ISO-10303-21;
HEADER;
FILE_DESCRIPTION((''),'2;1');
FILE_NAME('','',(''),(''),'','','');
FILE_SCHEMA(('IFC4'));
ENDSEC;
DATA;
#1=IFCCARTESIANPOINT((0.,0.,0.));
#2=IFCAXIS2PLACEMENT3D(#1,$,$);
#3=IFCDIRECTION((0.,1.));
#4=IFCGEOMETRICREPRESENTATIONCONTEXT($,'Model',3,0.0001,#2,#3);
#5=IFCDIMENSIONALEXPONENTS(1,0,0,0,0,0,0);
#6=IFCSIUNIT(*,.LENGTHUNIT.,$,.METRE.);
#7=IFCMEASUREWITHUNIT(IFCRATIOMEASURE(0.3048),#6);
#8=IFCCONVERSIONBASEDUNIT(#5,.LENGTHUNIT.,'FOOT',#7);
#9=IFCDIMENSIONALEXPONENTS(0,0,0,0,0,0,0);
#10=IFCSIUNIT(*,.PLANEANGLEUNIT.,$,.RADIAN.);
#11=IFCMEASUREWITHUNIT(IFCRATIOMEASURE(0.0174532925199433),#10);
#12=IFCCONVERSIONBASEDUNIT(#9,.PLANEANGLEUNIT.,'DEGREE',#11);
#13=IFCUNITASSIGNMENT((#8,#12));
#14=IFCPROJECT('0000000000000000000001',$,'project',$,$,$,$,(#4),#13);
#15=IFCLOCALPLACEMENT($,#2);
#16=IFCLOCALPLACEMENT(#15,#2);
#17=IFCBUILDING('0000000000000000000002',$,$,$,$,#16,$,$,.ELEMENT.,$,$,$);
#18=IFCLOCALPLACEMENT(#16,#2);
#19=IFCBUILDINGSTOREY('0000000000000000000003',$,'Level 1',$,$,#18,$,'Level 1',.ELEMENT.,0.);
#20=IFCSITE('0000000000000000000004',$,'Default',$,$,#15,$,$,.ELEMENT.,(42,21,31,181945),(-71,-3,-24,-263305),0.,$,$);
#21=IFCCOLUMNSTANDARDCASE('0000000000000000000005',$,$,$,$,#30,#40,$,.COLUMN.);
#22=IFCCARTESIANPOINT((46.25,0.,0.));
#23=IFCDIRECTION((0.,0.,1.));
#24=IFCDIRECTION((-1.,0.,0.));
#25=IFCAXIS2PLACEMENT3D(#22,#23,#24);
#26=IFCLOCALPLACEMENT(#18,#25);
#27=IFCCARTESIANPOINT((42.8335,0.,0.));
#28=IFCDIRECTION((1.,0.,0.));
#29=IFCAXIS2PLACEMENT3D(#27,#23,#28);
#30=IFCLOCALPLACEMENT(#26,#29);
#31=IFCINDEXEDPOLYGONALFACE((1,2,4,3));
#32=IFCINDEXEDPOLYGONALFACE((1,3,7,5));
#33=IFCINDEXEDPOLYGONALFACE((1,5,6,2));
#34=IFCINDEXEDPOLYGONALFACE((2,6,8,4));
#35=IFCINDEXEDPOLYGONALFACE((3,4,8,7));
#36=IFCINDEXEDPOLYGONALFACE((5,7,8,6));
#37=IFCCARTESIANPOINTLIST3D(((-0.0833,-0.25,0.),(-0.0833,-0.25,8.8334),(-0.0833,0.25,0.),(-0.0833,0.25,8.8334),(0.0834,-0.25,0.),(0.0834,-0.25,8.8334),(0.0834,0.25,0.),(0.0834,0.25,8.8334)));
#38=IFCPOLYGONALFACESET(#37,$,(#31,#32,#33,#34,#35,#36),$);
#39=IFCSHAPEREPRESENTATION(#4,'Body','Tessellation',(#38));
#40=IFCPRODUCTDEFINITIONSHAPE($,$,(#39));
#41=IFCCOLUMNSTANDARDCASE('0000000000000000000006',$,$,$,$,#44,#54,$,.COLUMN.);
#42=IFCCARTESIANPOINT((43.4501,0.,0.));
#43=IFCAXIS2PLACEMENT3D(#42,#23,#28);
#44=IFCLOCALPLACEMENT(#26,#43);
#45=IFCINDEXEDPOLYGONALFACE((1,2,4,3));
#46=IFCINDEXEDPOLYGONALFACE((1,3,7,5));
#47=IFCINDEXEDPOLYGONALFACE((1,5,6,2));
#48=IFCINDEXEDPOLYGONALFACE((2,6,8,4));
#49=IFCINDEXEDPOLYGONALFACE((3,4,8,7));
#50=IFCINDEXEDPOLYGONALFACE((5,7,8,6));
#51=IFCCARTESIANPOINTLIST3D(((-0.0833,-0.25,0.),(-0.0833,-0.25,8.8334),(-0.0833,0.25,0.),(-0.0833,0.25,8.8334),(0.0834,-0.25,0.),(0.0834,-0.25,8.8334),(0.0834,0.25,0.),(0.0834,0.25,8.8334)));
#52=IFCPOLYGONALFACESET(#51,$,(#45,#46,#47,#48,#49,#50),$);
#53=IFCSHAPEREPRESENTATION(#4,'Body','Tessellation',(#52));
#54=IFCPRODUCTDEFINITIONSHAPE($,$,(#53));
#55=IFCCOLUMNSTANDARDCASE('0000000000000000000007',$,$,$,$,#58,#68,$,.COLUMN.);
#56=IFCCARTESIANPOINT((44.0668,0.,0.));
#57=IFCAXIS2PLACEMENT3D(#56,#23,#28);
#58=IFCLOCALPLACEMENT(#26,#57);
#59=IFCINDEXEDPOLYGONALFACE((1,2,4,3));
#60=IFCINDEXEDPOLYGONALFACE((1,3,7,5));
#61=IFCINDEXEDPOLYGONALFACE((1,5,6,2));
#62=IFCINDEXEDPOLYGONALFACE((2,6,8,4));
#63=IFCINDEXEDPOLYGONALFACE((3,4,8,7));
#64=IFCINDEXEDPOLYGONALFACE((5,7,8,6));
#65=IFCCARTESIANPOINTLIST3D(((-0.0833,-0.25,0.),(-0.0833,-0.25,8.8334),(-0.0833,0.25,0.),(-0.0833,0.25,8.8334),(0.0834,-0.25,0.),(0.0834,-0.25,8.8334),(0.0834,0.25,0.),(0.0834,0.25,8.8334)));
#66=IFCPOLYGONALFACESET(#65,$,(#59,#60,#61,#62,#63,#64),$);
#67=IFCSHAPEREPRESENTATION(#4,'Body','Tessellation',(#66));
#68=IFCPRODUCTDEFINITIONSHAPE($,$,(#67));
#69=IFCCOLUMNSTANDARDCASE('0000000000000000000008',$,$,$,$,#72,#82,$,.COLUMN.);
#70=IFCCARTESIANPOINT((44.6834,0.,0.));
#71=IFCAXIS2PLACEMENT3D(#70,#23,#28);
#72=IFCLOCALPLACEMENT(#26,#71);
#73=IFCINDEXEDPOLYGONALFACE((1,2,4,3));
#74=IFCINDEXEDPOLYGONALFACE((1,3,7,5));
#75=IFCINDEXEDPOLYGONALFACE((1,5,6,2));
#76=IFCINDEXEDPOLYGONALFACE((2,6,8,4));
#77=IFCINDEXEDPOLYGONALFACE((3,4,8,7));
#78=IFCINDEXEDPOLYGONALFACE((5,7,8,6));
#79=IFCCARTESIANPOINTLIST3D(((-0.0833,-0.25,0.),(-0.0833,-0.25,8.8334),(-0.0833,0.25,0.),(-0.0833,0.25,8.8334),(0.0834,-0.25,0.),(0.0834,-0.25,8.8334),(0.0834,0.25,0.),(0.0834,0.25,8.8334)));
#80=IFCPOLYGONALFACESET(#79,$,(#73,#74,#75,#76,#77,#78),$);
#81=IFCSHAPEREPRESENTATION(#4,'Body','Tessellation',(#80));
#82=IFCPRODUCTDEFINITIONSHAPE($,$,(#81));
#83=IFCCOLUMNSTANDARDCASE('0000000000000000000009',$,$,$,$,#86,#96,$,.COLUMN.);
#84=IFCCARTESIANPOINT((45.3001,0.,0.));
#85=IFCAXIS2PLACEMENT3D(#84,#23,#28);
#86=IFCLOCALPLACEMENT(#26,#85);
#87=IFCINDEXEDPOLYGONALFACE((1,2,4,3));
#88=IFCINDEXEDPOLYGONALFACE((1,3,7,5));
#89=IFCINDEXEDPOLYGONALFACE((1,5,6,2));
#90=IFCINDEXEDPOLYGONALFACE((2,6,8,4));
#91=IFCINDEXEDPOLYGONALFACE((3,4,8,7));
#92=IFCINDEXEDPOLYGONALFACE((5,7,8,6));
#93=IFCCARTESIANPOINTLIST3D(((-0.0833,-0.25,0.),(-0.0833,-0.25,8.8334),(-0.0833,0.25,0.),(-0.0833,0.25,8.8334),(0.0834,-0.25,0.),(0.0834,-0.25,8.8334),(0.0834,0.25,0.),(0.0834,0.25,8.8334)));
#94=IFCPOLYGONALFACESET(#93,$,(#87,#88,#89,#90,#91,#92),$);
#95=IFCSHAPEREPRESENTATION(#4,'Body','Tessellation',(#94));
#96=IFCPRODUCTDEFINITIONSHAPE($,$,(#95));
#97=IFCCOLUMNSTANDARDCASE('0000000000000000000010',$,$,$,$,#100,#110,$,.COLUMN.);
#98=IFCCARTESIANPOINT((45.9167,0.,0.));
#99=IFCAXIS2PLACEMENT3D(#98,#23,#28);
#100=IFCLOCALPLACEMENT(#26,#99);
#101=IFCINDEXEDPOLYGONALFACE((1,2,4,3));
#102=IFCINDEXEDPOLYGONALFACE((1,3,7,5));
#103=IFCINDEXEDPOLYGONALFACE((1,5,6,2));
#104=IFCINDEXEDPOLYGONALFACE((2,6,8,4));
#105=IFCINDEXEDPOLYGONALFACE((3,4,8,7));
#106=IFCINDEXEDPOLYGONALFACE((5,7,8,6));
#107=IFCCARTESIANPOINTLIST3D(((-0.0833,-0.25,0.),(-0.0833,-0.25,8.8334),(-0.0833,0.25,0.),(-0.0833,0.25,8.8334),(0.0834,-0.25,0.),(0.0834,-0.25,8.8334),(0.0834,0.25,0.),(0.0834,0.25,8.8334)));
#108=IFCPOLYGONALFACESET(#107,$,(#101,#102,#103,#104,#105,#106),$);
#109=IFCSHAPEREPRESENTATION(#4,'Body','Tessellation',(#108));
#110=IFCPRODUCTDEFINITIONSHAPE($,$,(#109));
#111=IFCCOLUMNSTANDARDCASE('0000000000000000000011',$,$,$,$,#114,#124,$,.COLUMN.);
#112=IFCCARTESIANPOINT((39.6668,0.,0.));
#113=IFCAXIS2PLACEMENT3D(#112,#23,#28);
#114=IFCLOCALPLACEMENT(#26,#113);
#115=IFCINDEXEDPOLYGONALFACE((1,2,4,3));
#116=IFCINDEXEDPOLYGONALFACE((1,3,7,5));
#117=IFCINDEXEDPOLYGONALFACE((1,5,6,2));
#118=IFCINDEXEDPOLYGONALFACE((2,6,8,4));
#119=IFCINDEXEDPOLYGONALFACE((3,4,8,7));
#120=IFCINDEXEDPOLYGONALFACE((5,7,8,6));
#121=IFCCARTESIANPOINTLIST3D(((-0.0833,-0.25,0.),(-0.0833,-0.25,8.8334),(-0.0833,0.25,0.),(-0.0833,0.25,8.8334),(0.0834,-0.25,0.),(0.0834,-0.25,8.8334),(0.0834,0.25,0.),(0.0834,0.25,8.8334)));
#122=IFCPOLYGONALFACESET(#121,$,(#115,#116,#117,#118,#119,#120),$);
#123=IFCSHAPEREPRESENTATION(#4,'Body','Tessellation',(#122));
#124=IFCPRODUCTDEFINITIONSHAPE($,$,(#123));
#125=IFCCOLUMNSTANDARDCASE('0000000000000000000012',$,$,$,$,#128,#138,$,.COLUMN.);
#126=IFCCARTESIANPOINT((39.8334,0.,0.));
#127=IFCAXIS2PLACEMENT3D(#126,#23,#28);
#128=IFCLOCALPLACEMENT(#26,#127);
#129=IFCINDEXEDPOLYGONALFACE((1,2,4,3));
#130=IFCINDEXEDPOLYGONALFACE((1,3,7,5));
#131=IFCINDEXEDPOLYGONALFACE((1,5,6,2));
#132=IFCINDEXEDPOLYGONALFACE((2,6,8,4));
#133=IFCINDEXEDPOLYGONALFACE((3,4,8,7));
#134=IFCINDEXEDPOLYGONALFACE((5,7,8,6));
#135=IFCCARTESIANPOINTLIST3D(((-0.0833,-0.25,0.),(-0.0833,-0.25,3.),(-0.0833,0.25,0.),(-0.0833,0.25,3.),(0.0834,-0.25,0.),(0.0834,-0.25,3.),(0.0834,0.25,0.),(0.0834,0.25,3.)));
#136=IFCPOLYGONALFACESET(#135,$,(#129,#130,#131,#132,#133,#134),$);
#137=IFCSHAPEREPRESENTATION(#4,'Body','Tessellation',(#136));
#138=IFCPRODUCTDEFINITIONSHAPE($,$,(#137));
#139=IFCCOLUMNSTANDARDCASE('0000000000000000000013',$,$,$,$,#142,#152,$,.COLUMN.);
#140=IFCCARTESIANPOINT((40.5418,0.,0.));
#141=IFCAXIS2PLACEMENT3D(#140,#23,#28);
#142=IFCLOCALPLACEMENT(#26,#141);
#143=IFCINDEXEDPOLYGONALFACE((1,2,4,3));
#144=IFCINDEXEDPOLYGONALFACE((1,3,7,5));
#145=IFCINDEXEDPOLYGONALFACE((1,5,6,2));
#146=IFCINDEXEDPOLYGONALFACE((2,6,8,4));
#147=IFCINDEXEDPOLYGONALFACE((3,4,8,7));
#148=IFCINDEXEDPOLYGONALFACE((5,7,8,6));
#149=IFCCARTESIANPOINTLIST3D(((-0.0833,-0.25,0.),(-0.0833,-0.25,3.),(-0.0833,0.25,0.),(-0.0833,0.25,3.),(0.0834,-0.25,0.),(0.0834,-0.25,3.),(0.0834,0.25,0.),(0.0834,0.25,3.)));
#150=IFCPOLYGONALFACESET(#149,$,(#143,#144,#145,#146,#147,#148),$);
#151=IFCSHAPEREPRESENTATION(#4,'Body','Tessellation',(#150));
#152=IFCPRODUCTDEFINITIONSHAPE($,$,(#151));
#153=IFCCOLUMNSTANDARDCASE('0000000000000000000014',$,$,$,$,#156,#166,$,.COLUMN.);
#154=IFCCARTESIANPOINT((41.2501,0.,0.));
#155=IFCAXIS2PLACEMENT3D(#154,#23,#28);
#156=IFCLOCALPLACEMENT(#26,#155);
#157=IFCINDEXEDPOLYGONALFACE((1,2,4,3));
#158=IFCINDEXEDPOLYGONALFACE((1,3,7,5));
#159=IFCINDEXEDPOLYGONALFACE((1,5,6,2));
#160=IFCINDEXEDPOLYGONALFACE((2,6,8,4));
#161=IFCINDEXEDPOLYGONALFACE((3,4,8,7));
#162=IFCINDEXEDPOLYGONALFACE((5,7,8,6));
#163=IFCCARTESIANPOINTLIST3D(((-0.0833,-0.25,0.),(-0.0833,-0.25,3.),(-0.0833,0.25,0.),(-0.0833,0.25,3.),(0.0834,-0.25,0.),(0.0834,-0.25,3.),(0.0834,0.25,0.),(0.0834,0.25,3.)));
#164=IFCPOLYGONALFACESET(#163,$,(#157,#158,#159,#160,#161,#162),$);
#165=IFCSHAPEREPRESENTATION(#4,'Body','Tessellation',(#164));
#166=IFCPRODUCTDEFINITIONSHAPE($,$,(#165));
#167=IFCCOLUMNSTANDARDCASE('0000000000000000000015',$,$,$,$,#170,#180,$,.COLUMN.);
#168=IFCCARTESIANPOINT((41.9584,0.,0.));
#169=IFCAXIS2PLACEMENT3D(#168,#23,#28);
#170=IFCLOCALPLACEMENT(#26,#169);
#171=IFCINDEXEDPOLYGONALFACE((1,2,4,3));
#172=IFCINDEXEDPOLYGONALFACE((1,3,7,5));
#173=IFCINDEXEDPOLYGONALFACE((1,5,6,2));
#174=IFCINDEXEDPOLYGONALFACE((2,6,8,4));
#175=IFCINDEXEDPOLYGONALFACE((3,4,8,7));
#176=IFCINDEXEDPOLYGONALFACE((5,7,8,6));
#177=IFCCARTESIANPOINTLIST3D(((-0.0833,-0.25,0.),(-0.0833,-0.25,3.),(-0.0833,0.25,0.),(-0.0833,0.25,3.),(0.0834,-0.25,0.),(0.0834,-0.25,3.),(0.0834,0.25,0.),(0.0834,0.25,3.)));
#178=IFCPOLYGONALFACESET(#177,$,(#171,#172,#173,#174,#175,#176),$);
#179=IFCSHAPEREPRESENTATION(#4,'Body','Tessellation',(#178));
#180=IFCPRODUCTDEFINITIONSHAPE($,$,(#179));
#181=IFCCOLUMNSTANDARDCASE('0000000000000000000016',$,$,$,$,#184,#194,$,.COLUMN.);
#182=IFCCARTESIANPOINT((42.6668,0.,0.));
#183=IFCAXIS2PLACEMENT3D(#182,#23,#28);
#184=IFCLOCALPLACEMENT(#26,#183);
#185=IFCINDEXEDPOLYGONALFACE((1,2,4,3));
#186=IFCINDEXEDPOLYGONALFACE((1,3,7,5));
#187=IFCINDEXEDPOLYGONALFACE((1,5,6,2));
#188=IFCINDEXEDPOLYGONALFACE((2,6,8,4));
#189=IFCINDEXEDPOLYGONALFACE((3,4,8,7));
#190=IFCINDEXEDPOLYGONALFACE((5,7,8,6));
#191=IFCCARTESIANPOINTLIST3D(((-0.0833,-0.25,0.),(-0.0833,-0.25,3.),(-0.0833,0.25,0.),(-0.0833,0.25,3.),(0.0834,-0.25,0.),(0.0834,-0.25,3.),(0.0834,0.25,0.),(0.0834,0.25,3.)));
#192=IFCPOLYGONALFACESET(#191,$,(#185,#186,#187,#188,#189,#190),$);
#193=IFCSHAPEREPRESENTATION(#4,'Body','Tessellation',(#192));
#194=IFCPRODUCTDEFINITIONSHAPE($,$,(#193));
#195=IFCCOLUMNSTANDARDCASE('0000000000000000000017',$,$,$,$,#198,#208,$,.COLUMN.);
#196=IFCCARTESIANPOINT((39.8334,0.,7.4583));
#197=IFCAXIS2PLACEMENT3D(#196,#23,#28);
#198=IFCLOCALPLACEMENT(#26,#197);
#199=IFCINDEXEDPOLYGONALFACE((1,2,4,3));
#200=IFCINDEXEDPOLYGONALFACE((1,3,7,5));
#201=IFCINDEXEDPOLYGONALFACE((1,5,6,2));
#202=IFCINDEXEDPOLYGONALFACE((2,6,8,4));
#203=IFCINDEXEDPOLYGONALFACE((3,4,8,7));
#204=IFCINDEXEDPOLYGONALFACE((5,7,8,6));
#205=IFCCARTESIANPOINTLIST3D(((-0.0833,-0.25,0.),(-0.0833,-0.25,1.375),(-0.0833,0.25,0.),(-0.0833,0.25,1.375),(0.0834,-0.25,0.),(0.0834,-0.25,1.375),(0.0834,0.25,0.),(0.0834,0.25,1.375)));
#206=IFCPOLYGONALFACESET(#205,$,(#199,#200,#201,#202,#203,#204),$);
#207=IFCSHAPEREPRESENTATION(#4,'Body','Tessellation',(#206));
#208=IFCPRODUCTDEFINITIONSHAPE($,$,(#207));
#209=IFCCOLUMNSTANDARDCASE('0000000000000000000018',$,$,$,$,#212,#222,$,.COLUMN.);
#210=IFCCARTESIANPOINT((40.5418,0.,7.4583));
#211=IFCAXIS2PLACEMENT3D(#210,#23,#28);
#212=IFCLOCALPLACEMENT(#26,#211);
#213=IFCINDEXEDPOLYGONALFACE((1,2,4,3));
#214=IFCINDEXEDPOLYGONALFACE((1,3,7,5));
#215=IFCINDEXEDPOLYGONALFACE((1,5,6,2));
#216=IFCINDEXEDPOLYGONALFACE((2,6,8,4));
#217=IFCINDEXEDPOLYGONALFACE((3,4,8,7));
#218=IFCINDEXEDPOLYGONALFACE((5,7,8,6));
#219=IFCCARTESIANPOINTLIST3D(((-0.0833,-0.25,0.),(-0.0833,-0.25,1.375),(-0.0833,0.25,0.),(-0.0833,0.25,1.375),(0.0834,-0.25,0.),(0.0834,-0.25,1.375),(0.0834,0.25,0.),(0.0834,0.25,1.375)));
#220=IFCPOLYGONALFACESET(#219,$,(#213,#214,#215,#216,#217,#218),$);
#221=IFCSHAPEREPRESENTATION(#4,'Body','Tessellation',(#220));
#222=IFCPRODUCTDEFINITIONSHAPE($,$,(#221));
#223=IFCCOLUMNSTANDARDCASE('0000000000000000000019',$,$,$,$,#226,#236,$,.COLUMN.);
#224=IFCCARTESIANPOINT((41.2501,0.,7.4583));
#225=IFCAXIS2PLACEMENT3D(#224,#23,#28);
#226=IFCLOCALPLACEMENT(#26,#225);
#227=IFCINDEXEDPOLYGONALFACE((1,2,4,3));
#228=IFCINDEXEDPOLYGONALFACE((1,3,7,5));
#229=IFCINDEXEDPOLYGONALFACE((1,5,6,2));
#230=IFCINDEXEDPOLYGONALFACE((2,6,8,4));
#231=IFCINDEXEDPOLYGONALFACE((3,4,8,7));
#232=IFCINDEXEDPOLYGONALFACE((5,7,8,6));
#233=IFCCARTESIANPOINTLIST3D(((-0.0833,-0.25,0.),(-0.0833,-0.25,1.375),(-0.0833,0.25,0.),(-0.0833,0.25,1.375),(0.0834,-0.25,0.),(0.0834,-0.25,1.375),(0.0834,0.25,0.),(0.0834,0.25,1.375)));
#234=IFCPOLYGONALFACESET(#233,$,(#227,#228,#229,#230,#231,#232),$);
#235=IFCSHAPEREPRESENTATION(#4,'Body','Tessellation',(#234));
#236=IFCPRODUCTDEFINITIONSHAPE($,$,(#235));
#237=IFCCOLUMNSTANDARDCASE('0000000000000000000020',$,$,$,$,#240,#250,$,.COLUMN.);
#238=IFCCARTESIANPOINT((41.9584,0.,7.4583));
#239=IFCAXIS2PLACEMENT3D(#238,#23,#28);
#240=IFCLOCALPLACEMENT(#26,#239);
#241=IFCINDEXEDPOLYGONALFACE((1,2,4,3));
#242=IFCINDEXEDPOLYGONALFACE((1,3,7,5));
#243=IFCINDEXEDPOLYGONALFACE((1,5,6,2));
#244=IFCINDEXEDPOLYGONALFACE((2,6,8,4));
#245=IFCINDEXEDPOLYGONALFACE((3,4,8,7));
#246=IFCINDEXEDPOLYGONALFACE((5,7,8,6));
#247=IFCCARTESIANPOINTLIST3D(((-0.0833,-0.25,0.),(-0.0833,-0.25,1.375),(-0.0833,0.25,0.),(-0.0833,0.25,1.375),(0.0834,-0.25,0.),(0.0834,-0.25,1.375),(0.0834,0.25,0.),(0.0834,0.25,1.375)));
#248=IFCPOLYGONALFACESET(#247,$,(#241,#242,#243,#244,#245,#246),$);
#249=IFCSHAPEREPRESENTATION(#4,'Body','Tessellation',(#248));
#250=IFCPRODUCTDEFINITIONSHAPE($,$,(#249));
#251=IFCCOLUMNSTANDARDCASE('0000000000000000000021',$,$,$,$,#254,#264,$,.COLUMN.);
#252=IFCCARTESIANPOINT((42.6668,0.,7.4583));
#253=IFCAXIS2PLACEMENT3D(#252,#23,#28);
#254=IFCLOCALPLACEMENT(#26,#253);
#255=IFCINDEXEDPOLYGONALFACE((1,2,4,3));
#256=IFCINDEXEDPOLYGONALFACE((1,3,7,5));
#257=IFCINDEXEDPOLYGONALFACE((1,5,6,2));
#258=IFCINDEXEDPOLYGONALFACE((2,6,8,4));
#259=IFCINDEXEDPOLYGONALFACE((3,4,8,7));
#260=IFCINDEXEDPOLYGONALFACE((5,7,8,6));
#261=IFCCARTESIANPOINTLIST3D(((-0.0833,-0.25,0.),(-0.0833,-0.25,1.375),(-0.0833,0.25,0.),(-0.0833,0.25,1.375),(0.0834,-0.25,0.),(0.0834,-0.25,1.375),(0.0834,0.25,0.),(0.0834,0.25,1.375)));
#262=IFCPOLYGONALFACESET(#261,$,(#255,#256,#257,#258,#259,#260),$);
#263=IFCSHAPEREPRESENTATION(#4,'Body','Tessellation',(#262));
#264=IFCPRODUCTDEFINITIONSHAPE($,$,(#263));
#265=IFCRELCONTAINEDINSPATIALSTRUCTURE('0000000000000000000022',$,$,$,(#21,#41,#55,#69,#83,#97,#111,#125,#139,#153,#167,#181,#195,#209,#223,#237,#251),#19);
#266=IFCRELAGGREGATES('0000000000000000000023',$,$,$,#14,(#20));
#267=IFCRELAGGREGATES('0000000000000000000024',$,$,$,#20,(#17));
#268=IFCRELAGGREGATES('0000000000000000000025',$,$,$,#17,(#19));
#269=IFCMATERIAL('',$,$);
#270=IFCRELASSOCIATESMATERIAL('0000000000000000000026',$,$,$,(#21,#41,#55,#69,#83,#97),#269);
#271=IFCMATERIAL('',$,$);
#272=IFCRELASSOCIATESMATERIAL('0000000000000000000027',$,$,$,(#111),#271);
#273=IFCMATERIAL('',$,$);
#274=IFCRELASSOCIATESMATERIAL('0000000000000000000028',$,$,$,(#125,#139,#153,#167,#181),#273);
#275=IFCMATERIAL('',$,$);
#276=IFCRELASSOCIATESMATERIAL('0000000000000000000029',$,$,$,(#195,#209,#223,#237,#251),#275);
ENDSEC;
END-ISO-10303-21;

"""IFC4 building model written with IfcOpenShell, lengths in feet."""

from ifc_helpers import new_model, entity, si_unit, converted_unit, direction, frame, origin, place, context, project, spatial, rectangle, extrude, material, element, save


model = new_model("IFC4")

# Units and contexts
model_context = context("Model", 3, precision=0.0001, world=origin(), true_north=direction((0.0, 1.0)))
ifc_project = project(units=[converted_unit("LENGTHUNIT", "FOOT", entity("IfcRatioMeasure", 0.3048), si_unit("LENGTHUNIT", "METRE"), dimensions=[1, 0, 0, 0, 0, 0, 0]), converted_unit("PLANEANGLEUNIT", "DEGREE", entity("IfcRatioMeasure", 0.0174532925199433), si_unit("PLANEANGLEUNIT", "RADIAN"), dimensions=[0, 0, 0, 0, 0, 0, 0])], contexts=[model_context])

# Site, building, storey
site_placement = place(None, origin())
site = spatial("IfcSite", under=ifc_project, at=site_placement, Name="Default", CompositionType="ELEMENT", RefLatitude=(42, 21, 31, 181945), RefLongitude=(-71, -3, -24, -263305), RefElevation=0.0)
building_placement = place(site_placement, origin())
building = spatial("IfcBuilding", under=site, at=building_placement, CompositionType="ELEMENT")
storey_placement = place(building_placement, origin())
storey = spatial("IfcBuildingStorey", under=building, at=storey_placement, Name="Level 1", LongName="Level 1", CompositionType="ELEMENT", Elevation=0.0)

# Columns
ifc_material_1 = material(Name="")
placement_1 = place(storey_placement, frame((46.25, 0.0, 0.0), z_axis=(0.0, 0.0, 1.0), x_axis=(-1.0, 0.0, 0.0)))
for number, where, z_axis, x_axis in (
    (1, (42.8335, 0.0, 0.0), (0.0, 0.0, 1.0), (1.0, 0.0, 0.0)),
    (2, (43.4501, 0.0, 0.0), (0.0, 0.0, 1.0), (1.0, 0.0, 0.0)),
    (3, (44.0668, 0.0, 0.0), (0.0, 0.0, 1.0), (1.0, 0.0, 0.0)),
    (4, (44.6834, 0.0, 0.0), (0.0, 0.0, 1.0), (1.0, 0.0, 0.0)),
    (5, (45.3001, 0.0, 0.0), (0.0, 0.0, 1.0), (1.0, 0.0, 0.0)),
    (6, (45.9167, 0.0, 0.0), (0.0, 0.0, 1.0), (1.0, 0.0, 0.0)),
):
    element("IfcColumnStandardCase", number, at=place(placement_1, frame(where, z_axis=z_axis, x_axis=x_axis)), inside=storey, material=ifc_material_1, PredefinedType="COLUMN", context=model_context, shape_type="SweptSolid", body=[
        extrude(rectangle(XDim=0.1667, YDim=0.5), origin(), (0.0, 0.0, 1.0), 8.8334),
    ])
ifc_material_2 = material(Name="")
column_placement = place(placement_1, frame((39.6668, 0.0, 0.0), z_axis=(0.0, 0.0, 1.0), x_axis=(1.0, 0.0, 0.0)))
element("IfcColumnStandardCase", 7, at=column_placement, inside=storey, material=ifc_material_2, PredefinedType="COLUMN", context=model_context, shape_type="SweptSolid", body=[
    extrude(rectangle(XDim=0.1667, YDim=0.5), origin(), (0.0, 0.0, 1.0), 8.8334),
])
ifc_material_3 = material(Name="")
for number, where, z_axis, x_axis in (
    (8, (39.8334, 0.0, 0.0), (0.0, 0.0, 1.0), (1.0, 0.0, 0.0)),
    (9, (40.5418, 0.0, 0.0), (0.0, 0.0, 1.0), (1.0, 0.0, 0.0)),
    (10, (41.2501, 0.0, 0.0), (0.0, 0.0, 1.0), (1.0, 0.0, 0.0)),
    (11, (41.9584, 0.0, 0.0), (0.0, 0.0, 1.0), (1.0, 0.0, 0.0)),
    (12, (42.6668, 0.0, 0.0), (0.0, 0.0, 1.0), (1.0, 0.0, 0.0)),
):
    element("IfcColumnStandardCase", number, at=place(placement_1, frame(where, z_axis=z_axis, x_axis=x_axis)), inside=storey, material=ifc_material_3, PredefinedType="COLUMN", context=model_context, shape_type="SweptSolid", body=[
        extrude(rectangle(XDim=0.1667, YDim=0.5), origin(), (0.0, 0.0, 1.0), 3.0),
    ])
ifc_material_4 = material(Name="")
for number, where, z_axis, x_axis in (
    (13, (39.8334, 0.0, 7.4583), (0.0, 0.0, 1.0), (1.0, 0.0, 0.0)),
    (14, (40.5418, 0.0, 7.4583), (0.0, 0.0, 1.0), (1.0, 0.0, 0.0)),
    (15, (41.2501, 0.0, 7.4583), (0.0, 0.0, 1.0), (1.0, 0.0, 0.0)),
    (16, (41.9584, 0.0, 7.4583), (0.0, 0.0, 1.0), (1.0, 0.0, 0.0)),
    (17, (42.6668, 0.0, 7.4583), (0.0, 0.0, 1.0), (1.0, 0.0, 0.0)),
):
    element("IfcColumnStandardCase", number, at=place(placement_1, frame(where, z_axis=z_axis, x_axis=x_axis)), inside=storey, material=ifc_material_4, PredefinedType="COLUMN", context=model_context, shape_type="SweptSolid", body=[
        extrude(rectangle(XDim=0.1667, YDim=0.5), origin(), (0.0, 0.0, 1.0), 1.375),
    ])

save(model, "model.ifc")
